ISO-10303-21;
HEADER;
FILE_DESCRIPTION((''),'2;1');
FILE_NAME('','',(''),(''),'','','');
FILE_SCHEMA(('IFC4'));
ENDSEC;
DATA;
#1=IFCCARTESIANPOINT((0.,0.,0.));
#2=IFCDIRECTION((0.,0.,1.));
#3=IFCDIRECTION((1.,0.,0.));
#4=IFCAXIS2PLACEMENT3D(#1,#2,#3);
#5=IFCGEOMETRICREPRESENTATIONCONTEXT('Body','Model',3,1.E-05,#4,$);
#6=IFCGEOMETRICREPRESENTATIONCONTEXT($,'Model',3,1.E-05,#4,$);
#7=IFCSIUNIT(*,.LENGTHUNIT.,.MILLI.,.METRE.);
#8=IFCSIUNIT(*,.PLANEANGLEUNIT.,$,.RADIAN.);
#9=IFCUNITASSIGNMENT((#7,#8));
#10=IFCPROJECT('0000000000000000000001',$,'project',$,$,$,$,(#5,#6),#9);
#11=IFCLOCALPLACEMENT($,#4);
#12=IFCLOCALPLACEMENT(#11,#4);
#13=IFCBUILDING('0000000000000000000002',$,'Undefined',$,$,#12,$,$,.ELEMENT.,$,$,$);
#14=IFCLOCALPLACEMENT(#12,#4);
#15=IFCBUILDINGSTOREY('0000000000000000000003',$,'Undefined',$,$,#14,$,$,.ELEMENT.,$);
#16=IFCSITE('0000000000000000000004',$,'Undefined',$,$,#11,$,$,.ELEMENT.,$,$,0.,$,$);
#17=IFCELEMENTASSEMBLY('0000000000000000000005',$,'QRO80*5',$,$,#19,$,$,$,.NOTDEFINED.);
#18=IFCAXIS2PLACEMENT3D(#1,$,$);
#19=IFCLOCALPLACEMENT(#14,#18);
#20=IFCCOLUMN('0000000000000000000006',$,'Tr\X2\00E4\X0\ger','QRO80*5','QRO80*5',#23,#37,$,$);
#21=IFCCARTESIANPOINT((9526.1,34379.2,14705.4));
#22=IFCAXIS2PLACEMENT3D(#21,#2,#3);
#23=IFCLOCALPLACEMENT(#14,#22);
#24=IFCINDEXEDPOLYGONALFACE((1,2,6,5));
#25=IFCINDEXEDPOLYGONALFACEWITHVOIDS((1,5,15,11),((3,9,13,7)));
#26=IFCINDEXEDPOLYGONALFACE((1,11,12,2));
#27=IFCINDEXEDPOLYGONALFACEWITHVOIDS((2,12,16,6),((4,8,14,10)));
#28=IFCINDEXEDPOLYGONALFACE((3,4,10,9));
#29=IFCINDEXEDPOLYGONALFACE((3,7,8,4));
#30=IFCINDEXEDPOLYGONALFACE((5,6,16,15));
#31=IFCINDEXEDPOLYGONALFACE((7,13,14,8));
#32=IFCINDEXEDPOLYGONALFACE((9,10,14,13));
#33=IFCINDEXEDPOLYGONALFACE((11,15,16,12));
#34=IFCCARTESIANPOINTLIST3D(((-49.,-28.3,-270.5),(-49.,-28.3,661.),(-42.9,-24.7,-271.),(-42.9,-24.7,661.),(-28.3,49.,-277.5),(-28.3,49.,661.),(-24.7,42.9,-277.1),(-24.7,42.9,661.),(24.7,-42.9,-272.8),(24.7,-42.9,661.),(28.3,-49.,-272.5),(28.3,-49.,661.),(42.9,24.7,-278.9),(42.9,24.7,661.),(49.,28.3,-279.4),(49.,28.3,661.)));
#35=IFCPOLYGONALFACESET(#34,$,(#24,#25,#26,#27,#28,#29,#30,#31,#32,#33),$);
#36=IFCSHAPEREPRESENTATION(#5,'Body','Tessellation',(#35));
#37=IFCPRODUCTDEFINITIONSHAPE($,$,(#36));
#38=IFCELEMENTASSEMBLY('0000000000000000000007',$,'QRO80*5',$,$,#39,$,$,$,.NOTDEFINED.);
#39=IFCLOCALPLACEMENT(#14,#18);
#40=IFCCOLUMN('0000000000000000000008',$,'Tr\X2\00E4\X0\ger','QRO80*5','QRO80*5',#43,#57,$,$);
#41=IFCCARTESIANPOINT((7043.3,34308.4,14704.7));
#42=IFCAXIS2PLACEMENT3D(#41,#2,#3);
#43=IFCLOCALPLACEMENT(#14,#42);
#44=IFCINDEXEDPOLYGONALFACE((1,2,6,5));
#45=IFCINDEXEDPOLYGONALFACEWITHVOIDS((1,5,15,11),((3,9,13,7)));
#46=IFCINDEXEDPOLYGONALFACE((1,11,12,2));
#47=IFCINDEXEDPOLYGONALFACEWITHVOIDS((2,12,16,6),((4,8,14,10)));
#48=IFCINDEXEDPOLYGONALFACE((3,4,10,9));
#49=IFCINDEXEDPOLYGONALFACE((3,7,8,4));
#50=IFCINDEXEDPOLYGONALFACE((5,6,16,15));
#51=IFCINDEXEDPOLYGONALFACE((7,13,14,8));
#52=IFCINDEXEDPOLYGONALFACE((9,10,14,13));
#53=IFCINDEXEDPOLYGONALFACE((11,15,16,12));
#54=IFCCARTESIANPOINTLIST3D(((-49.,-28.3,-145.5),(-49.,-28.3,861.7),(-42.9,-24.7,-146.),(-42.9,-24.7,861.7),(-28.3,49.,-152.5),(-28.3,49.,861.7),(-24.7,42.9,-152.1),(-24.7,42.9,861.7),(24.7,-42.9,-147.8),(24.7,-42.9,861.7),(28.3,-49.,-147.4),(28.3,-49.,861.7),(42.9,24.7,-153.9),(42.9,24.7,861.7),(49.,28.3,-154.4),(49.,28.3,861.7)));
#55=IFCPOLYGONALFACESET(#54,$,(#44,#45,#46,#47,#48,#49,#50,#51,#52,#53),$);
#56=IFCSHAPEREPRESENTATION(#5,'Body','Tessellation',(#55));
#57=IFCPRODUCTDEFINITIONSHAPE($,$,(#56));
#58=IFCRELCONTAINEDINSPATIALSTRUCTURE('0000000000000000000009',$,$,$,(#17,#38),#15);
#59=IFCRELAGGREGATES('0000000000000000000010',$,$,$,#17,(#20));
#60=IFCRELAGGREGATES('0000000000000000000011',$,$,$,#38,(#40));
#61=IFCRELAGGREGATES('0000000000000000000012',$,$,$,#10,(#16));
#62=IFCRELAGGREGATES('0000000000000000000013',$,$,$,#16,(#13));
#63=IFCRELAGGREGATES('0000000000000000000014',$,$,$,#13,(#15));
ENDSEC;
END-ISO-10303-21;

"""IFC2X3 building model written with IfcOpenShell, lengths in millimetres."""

from ifc_helpers import new_model, si_unit, frame, origin_with_axes, origin_2d_with_axis, place, context, project, spatial, hollow_rectangle, extrude, clip, halfspace, element, aggregate, save


model = new_model("IFC2X3")

# Units and contexts
model_context_1 = context("Model", 3, precision=1e-05, world=origin_with_axes(), identifier="Body")
model_context_2 = context("Model", 3, precision=1e-05, world=origin_with_axes())
ifc_project = project(units=[si_unit("LENGTHUNIT", "METRE", prefix="MILLI"), si_unit("PLANEANGLEUNIT", "RADIAN")], contexts=[model_context_1, model_context_2])

# Site, building, storey
site_placement = place(None, origin_with_axes())
site = spatial("IfcSite", under=ifc_project, at=site_placement, Name="Undefined", CompositionType="ELEMENT", RefElevation=0.0)
building_placement = place(site_placement, origin_with_axes())
building = spatial("IfcBuilding", under=site, at=building_placement, Name="Undefined", CompositionType="ELEMENT")
storey_placement = place(building_placement, origin_with_axes())
storey = spatial("IfcBuildingStorey", under=building, at=storey_placement, Name="Undefined", CompositionType="ELEMENT")

# Element assemblies, columns
assembly_1 = element("IfcElementAssembly", 1, inside=storey, Name="QRO80*5", PredefinedType="NOTDEFINED")
column_1_placement = place(storey_placement, frame((9526.1, 34379.2, 14705.4), z_axis=(0.0, 0.0, 1.0), x_axis=(1.0, 0.0, 0.0)))
column_1 = element("IfcColumn", 2, at=column_1_placement, Name="Träger", Description="QRO80*5", ObjectType="QRO80*5", context=model_context_1, shape_type="Clipping", body=[
    clip(clip(extrude(hollow_rectangle(XDim=80.0, YDim=80.0, WallThickness=5.0, at=origin_2d_with_axis()), frame((0.0, 0.0, 661.0), z_axis=(0.0, 0.0, -1.0), x_axis=(-0.25892, -0.965899, 0.000004)), (0.0, 0.0, 1.0), 940.5), halfspace(frame((38.6, -10.4, 661.0), z_axis=(0.0, 0.0, -1.0), x_axis=(0.258822, 0.965925, 0.000005)), True)), halfspace(frame((38.6, -10.4, -276.0), z_axis=(0.046381, 0.077523, 0.995911), x_axis=(-0.255858, -0.962804, 0.086861)), True)),
])
aggregate(assembly_1, [column_1])
assembly_2 = element("IfcElementAssembly", 3, inside=storey, Name="QRO80*5", PredefinedType="NOTDEFINED")
column_2_placement = place(storey_placement, frame((7043.3, 34308.4, 14704.7), z_axis=(0.0, 0.0, 1.0), x_axis=(1.0, 0.0, 0.0)))
column_2 = element("IfcColumn", 4, at=column_2_placement, Name="Träger", Description="QRO80*5", ObjectType="QRO80*5", context=model_context_1, shape_type="Clipping", body=[
    clip(clip(extrude(hollow_rectangle(XDim=80.0, YDim=80.0, WallThickness=5.0, at=origin_2d_with_axis()), frame((0.0, 0.0, 861.7), z_axis=(0.0, 0.0, -1.0), x_axis=(-0.258926, -0.965897, -0.000005)), (0.0, 0.0, 1.0), 1016.2), halfspace(frame((-38.6, 10.4, 861.7), z_axis=(0.0, 0.0, -1.0), x_axis=(-0.258822, -0.965925, -0.000005)), True)), halfspace(frame((38.6, -10.4, -150.9), z_axis=(0.046434, 0.077723, 0.995893), x_axis=(-0.255853, -0.962787, 0.087068)), True)),
])
aggregate(assembly_2, [column_2])

save(model, "model.ifc")
